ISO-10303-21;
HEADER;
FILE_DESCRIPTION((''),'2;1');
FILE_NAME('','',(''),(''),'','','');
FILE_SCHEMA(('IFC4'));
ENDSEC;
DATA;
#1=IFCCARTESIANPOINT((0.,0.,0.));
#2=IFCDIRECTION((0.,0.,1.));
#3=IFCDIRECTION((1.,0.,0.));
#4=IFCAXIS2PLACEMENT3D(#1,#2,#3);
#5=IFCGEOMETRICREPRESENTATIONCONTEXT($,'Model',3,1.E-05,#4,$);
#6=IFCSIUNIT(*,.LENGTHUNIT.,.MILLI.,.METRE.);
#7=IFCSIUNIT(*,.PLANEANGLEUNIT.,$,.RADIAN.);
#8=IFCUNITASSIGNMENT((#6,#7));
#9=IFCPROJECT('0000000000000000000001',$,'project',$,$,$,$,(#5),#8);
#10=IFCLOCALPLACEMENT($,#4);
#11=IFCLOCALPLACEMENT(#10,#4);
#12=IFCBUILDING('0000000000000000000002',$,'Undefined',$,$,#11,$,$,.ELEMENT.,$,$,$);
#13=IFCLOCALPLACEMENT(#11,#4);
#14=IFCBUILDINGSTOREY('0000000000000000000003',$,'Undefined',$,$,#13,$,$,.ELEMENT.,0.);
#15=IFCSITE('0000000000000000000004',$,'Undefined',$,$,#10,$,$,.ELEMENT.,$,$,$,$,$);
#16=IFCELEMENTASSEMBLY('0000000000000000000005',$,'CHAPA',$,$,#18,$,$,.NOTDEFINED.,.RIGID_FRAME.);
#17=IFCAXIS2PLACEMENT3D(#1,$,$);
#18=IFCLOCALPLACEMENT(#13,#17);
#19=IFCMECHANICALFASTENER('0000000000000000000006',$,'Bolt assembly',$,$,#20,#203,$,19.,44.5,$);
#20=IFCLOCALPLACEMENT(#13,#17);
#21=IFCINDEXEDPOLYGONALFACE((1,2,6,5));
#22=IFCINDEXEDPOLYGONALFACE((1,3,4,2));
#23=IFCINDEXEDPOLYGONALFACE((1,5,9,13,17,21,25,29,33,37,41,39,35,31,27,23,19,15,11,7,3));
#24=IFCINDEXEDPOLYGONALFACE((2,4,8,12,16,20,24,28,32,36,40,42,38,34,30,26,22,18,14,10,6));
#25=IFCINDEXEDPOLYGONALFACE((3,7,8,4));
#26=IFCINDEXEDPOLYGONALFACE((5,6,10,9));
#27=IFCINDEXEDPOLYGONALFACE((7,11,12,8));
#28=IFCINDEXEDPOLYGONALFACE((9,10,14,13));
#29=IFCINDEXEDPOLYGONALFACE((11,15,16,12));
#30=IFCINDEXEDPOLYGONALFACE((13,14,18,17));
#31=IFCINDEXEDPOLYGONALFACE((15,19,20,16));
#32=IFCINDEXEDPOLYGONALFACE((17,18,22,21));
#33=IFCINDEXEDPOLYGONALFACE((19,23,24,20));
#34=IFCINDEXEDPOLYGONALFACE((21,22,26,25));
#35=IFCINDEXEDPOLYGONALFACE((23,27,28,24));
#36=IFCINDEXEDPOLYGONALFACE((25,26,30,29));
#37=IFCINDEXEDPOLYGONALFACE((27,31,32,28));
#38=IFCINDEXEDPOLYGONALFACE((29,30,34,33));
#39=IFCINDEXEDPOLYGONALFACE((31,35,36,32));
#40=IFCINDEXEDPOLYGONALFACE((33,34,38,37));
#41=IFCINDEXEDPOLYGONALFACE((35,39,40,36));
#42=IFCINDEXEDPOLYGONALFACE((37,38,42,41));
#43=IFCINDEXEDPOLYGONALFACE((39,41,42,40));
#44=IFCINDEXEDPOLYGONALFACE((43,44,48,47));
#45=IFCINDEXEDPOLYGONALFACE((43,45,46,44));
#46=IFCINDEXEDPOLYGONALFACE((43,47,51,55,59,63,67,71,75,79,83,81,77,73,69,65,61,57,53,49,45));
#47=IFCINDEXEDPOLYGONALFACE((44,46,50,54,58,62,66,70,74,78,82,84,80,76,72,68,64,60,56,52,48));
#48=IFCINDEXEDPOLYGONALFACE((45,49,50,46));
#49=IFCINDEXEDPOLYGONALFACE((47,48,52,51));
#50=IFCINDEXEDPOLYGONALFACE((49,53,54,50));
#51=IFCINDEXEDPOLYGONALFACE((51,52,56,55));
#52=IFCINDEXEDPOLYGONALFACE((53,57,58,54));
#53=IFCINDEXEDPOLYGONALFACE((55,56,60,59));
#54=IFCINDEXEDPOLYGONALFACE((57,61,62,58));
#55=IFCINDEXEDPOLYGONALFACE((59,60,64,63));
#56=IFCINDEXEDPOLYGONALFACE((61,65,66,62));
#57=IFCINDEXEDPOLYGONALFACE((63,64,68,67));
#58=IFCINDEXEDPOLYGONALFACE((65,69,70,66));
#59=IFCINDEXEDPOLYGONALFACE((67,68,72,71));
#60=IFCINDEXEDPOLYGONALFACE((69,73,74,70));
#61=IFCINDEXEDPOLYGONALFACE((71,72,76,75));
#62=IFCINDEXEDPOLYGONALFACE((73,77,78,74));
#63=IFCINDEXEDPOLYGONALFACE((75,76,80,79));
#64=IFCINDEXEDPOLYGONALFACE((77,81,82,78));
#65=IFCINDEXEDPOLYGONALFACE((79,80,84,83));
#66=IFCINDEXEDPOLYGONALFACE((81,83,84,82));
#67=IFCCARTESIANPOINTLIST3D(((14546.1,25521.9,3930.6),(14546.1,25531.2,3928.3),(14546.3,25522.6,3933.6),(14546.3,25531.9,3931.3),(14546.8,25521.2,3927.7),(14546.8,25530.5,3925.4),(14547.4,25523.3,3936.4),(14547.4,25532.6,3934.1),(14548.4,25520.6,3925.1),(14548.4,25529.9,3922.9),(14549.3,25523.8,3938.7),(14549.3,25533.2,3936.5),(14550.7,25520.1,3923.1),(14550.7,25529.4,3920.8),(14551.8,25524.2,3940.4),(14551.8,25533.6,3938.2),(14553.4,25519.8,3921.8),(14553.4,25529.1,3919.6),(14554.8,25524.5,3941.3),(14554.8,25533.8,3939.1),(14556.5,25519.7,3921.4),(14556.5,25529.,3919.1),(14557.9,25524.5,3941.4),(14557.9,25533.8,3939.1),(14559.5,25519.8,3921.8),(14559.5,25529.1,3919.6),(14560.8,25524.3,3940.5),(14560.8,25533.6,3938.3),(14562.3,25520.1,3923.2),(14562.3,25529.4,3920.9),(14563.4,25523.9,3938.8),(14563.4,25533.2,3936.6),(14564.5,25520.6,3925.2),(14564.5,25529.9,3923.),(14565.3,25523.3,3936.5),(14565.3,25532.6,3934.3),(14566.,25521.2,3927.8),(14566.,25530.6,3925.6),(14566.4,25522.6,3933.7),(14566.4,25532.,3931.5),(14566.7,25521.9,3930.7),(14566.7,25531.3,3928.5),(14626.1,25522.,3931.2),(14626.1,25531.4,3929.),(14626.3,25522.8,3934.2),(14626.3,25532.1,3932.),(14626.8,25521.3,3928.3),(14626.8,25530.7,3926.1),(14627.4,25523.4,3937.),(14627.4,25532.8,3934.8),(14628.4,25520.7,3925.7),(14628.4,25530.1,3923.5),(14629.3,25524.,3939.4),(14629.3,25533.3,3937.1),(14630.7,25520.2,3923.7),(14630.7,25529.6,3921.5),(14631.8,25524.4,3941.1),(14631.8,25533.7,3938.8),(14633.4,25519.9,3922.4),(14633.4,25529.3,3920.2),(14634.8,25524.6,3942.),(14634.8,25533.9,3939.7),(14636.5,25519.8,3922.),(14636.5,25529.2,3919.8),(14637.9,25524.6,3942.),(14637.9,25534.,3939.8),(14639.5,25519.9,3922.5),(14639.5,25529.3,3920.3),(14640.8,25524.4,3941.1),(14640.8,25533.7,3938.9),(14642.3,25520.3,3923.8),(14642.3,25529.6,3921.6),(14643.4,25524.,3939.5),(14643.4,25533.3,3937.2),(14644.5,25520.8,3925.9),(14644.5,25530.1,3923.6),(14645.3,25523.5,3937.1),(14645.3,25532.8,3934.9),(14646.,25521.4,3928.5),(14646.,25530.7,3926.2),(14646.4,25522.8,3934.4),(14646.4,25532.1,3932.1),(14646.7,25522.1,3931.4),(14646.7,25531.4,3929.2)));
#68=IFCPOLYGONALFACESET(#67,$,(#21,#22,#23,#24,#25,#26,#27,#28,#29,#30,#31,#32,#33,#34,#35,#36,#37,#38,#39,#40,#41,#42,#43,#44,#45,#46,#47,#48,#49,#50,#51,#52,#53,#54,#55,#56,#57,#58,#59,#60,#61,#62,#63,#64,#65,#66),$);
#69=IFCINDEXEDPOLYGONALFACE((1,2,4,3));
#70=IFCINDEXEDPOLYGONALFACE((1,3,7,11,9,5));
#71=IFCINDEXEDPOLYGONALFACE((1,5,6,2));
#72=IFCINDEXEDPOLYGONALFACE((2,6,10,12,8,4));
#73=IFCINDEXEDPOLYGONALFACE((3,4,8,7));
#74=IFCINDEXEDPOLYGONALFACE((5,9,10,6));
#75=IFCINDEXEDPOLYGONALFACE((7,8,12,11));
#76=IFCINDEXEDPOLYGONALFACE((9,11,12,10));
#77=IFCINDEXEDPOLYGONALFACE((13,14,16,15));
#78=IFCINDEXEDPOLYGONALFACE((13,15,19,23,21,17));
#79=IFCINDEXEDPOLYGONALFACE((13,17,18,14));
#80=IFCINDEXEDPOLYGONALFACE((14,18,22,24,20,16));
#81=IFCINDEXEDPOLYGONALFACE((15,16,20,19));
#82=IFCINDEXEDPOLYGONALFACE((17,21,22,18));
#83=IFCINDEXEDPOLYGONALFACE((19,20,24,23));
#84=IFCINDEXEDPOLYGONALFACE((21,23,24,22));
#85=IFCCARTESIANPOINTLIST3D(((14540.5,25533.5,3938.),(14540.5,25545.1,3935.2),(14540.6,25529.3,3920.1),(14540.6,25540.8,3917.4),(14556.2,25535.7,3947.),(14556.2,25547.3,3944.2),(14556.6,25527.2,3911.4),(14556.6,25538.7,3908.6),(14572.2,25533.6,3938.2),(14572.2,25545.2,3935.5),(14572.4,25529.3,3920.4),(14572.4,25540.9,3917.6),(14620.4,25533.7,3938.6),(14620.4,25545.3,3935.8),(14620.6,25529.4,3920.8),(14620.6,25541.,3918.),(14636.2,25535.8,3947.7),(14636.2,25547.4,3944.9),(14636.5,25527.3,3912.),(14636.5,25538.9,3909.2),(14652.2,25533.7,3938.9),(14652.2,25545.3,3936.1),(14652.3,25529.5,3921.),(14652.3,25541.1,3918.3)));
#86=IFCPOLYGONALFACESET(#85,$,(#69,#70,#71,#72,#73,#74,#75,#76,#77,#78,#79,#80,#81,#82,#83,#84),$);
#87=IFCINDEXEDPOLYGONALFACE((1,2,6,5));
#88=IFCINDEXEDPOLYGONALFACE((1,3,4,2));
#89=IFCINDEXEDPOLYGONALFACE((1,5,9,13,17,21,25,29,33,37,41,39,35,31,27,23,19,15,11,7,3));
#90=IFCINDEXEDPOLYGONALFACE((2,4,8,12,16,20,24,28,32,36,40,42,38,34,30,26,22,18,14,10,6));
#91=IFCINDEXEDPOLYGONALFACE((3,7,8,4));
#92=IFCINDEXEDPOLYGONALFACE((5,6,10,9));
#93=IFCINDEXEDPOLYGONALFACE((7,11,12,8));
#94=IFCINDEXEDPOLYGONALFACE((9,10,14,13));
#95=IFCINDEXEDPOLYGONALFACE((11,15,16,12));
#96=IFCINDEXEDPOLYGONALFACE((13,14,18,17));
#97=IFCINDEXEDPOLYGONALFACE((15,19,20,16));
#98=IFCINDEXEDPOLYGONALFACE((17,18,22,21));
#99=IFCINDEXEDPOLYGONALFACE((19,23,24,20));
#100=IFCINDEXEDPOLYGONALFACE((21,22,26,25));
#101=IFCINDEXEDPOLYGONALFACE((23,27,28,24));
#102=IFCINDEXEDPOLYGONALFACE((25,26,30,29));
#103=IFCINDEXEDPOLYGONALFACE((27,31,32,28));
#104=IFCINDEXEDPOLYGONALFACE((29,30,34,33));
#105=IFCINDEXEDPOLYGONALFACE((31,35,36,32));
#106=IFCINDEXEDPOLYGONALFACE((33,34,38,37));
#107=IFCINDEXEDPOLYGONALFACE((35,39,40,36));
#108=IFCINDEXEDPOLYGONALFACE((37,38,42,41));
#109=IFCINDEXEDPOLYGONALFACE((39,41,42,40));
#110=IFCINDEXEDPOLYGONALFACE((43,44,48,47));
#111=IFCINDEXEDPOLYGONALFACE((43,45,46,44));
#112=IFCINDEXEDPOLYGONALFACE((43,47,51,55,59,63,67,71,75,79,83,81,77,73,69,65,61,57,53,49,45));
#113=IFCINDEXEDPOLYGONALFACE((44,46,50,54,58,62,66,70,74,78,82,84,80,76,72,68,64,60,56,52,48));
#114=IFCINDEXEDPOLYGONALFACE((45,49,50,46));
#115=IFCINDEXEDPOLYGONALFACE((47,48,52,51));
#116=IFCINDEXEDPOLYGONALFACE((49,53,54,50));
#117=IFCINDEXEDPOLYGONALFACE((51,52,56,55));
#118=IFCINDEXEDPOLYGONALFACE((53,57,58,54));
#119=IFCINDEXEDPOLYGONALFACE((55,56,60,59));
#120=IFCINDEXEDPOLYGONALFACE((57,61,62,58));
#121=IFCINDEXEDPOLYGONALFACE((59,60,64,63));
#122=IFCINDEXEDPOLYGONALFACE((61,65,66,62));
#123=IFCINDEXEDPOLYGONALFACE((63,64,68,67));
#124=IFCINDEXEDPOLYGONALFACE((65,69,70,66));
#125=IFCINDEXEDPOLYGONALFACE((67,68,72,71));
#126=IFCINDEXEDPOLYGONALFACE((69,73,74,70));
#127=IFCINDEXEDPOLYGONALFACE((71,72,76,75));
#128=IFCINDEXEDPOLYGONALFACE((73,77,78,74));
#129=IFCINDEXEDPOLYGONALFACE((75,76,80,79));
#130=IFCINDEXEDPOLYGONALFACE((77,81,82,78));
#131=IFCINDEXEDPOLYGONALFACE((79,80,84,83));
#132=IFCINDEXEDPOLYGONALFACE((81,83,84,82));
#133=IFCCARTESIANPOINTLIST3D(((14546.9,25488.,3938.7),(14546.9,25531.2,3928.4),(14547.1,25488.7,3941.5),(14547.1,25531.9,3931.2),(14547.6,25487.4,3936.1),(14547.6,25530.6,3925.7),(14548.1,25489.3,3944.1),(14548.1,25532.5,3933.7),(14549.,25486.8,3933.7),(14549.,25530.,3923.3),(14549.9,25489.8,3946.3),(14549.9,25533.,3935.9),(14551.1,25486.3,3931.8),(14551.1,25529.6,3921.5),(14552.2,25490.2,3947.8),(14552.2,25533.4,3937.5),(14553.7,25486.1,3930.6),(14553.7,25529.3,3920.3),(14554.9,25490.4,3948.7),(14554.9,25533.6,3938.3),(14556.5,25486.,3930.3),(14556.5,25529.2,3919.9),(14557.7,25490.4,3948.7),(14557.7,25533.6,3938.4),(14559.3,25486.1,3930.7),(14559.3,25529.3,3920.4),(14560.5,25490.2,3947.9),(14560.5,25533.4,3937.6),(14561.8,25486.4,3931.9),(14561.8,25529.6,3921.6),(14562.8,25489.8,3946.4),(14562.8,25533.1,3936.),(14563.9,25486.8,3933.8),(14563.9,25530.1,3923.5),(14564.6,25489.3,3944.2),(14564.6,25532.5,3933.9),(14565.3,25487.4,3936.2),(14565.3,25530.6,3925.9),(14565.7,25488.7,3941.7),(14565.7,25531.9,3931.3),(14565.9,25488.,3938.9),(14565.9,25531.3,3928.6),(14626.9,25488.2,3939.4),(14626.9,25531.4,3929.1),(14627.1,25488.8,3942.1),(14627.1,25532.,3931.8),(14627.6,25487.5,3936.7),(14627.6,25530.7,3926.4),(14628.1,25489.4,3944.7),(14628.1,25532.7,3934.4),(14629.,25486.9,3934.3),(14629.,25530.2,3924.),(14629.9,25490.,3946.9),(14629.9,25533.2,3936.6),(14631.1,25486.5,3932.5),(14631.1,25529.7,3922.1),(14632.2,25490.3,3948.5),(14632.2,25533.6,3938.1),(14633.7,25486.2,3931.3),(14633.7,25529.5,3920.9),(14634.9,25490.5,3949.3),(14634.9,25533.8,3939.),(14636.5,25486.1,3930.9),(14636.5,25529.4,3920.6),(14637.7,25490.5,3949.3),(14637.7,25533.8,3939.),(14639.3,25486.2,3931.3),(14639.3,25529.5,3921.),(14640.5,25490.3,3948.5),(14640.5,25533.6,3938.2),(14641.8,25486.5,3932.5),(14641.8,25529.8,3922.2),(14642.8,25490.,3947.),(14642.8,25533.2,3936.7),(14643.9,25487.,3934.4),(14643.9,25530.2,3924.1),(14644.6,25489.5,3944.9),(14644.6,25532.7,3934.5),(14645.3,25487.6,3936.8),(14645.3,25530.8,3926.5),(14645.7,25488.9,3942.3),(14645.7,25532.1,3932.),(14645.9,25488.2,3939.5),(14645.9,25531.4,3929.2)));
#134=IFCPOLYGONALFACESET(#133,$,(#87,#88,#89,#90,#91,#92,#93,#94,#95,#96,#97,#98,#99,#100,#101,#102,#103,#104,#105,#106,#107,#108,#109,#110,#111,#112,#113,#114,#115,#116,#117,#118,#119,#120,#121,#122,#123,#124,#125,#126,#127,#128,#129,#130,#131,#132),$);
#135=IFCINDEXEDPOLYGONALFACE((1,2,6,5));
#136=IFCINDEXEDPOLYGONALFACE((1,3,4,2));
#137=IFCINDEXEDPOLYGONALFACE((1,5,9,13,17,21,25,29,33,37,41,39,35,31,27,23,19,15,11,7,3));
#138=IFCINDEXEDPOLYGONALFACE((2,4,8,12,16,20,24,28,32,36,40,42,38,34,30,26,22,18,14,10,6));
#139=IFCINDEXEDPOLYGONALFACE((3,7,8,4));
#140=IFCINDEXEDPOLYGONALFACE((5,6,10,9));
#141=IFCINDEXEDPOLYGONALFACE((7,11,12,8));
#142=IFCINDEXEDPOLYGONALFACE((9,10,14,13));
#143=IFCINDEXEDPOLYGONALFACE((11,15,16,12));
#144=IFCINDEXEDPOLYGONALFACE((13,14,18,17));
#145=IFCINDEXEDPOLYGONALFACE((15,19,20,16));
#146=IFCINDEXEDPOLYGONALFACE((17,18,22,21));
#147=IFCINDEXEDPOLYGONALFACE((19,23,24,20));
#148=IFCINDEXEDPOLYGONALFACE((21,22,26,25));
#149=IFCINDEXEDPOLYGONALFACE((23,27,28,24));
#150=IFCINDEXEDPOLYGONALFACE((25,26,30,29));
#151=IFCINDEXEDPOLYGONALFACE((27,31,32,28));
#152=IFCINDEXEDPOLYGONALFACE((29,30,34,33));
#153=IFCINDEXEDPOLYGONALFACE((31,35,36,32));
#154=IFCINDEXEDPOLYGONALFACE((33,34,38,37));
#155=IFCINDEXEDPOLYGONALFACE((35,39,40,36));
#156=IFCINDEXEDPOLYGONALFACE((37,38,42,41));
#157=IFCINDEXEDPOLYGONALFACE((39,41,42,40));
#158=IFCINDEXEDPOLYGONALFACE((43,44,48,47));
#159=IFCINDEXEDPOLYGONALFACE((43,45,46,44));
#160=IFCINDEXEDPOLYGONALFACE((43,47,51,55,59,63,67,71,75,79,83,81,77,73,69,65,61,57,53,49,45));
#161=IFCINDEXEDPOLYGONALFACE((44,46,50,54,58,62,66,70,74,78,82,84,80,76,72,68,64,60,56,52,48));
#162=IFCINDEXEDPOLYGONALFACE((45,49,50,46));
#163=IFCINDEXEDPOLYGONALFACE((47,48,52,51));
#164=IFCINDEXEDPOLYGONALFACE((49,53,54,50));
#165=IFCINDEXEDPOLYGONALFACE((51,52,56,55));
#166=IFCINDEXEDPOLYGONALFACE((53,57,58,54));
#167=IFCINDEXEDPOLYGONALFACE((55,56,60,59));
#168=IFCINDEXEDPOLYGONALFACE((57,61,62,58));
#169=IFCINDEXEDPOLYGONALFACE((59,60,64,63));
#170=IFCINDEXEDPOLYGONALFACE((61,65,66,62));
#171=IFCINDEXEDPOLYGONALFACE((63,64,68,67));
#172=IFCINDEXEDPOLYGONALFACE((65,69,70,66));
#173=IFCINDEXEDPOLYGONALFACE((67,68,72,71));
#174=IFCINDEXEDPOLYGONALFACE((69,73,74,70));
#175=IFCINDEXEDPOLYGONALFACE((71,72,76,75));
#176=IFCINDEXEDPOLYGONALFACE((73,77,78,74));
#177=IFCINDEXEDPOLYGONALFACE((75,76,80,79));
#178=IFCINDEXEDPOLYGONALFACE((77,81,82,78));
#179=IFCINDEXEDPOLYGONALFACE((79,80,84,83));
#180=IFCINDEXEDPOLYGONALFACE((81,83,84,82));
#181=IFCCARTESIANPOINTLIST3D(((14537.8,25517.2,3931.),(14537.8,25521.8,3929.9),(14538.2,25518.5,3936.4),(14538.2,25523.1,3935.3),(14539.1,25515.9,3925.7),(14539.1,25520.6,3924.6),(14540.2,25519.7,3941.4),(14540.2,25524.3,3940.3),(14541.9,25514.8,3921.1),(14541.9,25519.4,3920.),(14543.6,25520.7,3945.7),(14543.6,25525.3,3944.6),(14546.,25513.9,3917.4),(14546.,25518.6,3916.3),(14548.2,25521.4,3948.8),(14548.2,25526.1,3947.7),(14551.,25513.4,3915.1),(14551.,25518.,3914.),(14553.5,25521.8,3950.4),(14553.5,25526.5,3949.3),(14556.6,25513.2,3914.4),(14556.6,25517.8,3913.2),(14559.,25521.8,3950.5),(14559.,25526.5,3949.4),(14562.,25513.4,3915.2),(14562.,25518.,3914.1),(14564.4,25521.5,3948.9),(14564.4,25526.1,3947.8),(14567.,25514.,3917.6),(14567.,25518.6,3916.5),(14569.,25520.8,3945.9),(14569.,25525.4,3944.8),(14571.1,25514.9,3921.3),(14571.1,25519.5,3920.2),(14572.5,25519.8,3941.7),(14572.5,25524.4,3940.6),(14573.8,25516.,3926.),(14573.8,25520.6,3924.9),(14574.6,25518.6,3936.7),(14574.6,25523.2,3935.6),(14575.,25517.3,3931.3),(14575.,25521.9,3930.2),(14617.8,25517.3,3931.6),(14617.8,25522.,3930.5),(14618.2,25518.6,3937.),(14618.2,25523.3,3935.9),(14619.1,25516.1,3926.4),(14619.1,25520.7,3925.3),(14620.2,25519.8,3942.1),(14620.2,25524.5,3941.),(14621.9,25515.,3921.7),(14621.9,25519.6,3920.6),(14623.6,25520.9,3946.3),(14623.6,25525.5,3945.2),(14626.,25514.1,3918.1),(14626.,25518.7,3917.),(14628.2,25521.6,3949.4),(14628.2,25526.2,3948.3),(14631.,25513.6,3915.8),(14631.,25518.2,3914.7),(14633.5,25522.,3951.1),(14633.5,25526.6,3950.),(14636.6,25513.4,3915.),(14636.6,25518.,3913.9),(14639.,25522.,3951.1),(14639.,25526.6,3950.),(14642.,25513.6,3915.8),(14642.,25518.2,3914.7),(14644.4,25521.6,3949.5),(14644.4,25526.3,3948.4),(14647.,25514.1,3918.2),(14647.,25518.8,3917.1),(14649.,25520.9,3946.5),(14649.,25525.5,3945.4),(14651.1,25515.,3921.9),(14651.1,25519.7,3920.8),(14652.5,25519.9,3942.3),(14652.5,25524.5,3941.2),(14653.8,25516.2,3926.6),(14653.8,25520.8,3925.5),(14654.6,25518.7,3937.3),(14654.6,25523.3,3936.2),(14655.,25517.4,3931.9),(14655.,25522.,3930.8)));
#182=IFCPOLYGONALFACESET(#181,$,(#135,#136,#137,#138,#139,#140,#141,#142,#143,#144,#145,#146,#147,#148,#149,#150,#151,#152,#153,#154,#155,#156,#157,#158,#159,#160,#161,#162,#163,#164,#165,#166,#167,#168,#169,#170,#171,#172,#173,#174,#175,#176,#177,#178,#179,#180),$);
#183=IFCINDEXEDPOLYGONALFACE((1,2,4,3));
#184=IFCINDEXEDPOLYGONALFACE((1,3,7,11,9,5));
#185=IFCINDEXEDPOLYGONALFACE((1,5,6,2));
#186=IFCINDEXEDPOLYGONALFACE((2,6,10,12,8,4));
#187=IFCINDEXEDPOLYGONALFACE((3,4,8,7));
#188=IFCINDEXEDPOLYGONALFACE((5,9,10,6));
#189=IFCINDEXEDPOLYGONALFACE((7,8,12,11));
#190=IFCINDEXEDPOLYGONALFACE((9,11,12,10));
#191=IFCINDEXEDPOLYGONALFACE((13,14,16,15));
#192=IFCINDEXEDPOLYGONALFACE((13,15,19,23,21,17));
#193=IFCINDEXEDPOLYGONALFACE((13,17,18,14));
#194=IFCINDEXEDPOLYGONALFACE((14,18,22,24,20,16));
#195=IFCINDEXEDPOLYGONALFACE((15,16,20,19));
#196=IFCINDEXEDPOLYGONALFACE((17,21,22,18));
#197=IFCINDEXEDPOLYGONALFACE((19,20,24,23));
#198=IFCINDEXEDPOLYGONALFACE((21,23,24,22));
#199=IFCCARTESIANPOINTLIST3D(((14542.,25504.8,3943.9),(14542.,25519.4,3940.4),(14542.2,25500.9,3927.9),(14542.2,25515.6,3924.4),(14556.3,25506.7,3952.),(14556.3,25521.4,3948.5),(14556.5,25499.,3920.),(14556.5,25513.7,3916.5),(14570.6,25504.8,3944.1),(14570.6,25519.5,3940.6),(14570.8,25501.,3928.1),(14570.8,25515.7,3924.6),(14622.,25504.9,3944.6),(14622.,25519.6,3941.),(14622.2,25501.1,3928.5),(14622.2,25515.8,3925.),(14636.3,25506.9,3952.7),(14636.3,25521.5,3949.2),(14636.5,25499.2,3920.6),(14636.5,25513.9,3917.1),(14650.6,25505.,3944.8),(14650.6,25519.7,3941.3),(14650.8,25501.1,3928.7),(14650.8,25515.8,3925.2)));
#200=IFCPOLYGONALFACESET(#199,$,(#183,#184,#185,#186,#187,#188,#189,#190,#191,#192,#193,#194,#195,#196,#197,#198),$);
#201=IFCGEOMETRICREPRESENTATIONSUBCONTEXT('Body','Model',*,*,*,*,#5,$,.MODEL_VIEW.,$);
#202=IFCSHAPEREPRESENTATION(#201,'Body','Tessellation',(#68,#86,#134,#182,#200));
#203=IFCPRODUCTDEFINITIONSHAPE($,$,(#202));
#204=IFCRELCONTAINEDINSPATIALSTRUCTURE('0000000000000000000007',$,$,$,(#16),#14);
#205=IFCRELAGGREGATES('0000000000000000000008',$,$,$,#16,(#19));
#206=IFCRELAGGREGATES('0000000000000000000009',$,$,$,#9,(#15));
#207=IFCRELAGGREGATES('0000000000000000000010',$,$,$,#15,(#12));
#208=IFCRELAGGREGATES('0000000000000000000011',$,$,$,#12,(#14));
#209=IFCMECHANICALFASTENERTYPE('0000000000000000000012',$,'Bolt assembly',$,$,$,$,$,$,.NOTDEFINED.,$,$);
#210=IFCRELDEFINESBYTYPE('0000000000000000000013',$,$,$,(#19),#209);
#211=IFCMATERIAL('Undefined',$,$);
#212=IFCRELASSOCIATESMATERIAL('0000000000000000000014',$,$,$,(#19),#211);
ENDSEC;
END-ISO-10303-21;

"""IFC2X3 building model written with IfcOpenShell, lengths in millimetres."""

from ifc_helpers import new_model, si_unit, frame, origin_with_axes, origin_2d_with_axis, place, context, subcontext, project, spatial, polyline, circle, outline, extrude, source, transform, mapped, material, type_object, element, aggregate, save


model = new_model("IFC2X3")

# Units and contexts
model_context = context("Model", 3, precision=1e-05, world=origin_with_axes())
body_context = subcontext(model_context, "Body", "Model", "MODEL_VIEW")
ifc_project = project(units=[si_unit("LENGTHUNIT", "METRE", prefix="MILLI"), si_unit("PLANEANGLEUNIT", "RADIAN")], contexts=[model_context])

# Site, building, storey
site_placement = place(None, origin_with_axes())
site = spatial("IfcSite", under=ifc_project, at=site_placement, Name="Undefined", CompositionType="ELEMENT")
building_placement = place(site_placement, origin_with_axes())
building = spatial("IfcBuilding", under=site, at=building_placement, Name="Undefined", CompositionType="ELEMENT")
storey_placement = place(building_placement, origin_with_axes())
storey = spatial("IfcBuildingStorey", under=building, at=storey_placement, Name="Undefined", CompositionType="ELEMENT", Elevation=0.0)

# Element assembly
assembly_1_placement = place(storey_placement, origin_with_axes())
assembly_1 = element("IfcElementAssembly", 1, at=assembly_1_placement, inside=storey, Name="CHAPA", AssemblyPlace="NOTDEFINED", PredefinedType="RIGID_FRAME")

# Shared definitions
ifc_material_1 = material(Name="Undefined")
mechanical_fastener_type = type_object("IfcMechanicalFastenerType", Name="Bolt assembly")

# Mechanical fastener
shared_shape_1 = source(origin_with_axes(), body_context, "Body", "SweptSolid", [
    extrude(circle(Radius=10.3, at=origin_2d_with_axis()), frame((0.0, 0.0, 0.0), z_axis=(0.0, 1.0, 0.0), x_axis=(1.0, 0.0, 0.0)), (0.0, 0.0, 1.0), 9.6),
    extrude(outline(polyline([(18.3, 0.0), (9.2, 15.9), (-9.2, 15.9), (-18.3, 0.0), (-9.2, -15.9), (9.2, -15.9), (18.3, 0.0)])), frame((0.0, -11.9, 0.0), z_axis=(0.0, 1.0, 0.0), x_axis=(1.0, 0.0, 0.0)), (0.0, 0.0, 1.0), 11.9),
    extrude(circle(Radius=9.5, at=origin_2d_with_axis()), frame((0.0, 0.0, 0.0), z_axis=(0.0, 1.0, 0.0), x_axis=(1.0, 0.0, 0.0)), (0.0, 0.0, 1.0), 44.5),
    extrude(circle(Radius=18.7, at=origin_2d_with_axis()), frame((0.0, 9.5, 0.0), z_axis=(0.0, 1.0, 0.0), x_axis=(1.0, 0.0, 0.0)), (0.0, 0.0, 1.0), 4.8),
    extrude(outline(polyline([(16.5, 0.0), (8.2, 14.3), (-8.2, 14.3), (-16.5, 0.0), (-8.2, -14.3), (8.2, -14.3), (16.5, 0.0)])), frame((0.0, 14.3, 0.0), z_axis=(0.0, 1.0, 0.0), x_axis=(1.0, 0.0, 0.0)), (0.0, 0.0, 1.0), 15.1),
])
mechanical_fastener_1_placement = place(assembly_1_placement, frame((14596.4, 25531.5, 3929.5), z_axis=(-0.999966, -0.001919, -0.008026), x_axis=(0.008253, -0.23249, -0.972564)))
mechanical_fastener_1 = element("IfcMechanicalFastener", 2, at=mechanical_fastener_1_placement, type_object=mechanical_fastener_type, material=ifc_material_1, Name="Bolt assembly", NominalDiameter=19.0, NominalLength=44.5, context=body_context, shape_type="MappedRepresentation", body=[
    mapped(shared_shape_1, transform((0.0, 0.0, 40.0))),
    mapped(shared_shape_1, transform((0.0, 0.0, -40.0))),
])
aggregate(assembly_1, [mechanical_fastener_1])

save(model, "model.ifc")
